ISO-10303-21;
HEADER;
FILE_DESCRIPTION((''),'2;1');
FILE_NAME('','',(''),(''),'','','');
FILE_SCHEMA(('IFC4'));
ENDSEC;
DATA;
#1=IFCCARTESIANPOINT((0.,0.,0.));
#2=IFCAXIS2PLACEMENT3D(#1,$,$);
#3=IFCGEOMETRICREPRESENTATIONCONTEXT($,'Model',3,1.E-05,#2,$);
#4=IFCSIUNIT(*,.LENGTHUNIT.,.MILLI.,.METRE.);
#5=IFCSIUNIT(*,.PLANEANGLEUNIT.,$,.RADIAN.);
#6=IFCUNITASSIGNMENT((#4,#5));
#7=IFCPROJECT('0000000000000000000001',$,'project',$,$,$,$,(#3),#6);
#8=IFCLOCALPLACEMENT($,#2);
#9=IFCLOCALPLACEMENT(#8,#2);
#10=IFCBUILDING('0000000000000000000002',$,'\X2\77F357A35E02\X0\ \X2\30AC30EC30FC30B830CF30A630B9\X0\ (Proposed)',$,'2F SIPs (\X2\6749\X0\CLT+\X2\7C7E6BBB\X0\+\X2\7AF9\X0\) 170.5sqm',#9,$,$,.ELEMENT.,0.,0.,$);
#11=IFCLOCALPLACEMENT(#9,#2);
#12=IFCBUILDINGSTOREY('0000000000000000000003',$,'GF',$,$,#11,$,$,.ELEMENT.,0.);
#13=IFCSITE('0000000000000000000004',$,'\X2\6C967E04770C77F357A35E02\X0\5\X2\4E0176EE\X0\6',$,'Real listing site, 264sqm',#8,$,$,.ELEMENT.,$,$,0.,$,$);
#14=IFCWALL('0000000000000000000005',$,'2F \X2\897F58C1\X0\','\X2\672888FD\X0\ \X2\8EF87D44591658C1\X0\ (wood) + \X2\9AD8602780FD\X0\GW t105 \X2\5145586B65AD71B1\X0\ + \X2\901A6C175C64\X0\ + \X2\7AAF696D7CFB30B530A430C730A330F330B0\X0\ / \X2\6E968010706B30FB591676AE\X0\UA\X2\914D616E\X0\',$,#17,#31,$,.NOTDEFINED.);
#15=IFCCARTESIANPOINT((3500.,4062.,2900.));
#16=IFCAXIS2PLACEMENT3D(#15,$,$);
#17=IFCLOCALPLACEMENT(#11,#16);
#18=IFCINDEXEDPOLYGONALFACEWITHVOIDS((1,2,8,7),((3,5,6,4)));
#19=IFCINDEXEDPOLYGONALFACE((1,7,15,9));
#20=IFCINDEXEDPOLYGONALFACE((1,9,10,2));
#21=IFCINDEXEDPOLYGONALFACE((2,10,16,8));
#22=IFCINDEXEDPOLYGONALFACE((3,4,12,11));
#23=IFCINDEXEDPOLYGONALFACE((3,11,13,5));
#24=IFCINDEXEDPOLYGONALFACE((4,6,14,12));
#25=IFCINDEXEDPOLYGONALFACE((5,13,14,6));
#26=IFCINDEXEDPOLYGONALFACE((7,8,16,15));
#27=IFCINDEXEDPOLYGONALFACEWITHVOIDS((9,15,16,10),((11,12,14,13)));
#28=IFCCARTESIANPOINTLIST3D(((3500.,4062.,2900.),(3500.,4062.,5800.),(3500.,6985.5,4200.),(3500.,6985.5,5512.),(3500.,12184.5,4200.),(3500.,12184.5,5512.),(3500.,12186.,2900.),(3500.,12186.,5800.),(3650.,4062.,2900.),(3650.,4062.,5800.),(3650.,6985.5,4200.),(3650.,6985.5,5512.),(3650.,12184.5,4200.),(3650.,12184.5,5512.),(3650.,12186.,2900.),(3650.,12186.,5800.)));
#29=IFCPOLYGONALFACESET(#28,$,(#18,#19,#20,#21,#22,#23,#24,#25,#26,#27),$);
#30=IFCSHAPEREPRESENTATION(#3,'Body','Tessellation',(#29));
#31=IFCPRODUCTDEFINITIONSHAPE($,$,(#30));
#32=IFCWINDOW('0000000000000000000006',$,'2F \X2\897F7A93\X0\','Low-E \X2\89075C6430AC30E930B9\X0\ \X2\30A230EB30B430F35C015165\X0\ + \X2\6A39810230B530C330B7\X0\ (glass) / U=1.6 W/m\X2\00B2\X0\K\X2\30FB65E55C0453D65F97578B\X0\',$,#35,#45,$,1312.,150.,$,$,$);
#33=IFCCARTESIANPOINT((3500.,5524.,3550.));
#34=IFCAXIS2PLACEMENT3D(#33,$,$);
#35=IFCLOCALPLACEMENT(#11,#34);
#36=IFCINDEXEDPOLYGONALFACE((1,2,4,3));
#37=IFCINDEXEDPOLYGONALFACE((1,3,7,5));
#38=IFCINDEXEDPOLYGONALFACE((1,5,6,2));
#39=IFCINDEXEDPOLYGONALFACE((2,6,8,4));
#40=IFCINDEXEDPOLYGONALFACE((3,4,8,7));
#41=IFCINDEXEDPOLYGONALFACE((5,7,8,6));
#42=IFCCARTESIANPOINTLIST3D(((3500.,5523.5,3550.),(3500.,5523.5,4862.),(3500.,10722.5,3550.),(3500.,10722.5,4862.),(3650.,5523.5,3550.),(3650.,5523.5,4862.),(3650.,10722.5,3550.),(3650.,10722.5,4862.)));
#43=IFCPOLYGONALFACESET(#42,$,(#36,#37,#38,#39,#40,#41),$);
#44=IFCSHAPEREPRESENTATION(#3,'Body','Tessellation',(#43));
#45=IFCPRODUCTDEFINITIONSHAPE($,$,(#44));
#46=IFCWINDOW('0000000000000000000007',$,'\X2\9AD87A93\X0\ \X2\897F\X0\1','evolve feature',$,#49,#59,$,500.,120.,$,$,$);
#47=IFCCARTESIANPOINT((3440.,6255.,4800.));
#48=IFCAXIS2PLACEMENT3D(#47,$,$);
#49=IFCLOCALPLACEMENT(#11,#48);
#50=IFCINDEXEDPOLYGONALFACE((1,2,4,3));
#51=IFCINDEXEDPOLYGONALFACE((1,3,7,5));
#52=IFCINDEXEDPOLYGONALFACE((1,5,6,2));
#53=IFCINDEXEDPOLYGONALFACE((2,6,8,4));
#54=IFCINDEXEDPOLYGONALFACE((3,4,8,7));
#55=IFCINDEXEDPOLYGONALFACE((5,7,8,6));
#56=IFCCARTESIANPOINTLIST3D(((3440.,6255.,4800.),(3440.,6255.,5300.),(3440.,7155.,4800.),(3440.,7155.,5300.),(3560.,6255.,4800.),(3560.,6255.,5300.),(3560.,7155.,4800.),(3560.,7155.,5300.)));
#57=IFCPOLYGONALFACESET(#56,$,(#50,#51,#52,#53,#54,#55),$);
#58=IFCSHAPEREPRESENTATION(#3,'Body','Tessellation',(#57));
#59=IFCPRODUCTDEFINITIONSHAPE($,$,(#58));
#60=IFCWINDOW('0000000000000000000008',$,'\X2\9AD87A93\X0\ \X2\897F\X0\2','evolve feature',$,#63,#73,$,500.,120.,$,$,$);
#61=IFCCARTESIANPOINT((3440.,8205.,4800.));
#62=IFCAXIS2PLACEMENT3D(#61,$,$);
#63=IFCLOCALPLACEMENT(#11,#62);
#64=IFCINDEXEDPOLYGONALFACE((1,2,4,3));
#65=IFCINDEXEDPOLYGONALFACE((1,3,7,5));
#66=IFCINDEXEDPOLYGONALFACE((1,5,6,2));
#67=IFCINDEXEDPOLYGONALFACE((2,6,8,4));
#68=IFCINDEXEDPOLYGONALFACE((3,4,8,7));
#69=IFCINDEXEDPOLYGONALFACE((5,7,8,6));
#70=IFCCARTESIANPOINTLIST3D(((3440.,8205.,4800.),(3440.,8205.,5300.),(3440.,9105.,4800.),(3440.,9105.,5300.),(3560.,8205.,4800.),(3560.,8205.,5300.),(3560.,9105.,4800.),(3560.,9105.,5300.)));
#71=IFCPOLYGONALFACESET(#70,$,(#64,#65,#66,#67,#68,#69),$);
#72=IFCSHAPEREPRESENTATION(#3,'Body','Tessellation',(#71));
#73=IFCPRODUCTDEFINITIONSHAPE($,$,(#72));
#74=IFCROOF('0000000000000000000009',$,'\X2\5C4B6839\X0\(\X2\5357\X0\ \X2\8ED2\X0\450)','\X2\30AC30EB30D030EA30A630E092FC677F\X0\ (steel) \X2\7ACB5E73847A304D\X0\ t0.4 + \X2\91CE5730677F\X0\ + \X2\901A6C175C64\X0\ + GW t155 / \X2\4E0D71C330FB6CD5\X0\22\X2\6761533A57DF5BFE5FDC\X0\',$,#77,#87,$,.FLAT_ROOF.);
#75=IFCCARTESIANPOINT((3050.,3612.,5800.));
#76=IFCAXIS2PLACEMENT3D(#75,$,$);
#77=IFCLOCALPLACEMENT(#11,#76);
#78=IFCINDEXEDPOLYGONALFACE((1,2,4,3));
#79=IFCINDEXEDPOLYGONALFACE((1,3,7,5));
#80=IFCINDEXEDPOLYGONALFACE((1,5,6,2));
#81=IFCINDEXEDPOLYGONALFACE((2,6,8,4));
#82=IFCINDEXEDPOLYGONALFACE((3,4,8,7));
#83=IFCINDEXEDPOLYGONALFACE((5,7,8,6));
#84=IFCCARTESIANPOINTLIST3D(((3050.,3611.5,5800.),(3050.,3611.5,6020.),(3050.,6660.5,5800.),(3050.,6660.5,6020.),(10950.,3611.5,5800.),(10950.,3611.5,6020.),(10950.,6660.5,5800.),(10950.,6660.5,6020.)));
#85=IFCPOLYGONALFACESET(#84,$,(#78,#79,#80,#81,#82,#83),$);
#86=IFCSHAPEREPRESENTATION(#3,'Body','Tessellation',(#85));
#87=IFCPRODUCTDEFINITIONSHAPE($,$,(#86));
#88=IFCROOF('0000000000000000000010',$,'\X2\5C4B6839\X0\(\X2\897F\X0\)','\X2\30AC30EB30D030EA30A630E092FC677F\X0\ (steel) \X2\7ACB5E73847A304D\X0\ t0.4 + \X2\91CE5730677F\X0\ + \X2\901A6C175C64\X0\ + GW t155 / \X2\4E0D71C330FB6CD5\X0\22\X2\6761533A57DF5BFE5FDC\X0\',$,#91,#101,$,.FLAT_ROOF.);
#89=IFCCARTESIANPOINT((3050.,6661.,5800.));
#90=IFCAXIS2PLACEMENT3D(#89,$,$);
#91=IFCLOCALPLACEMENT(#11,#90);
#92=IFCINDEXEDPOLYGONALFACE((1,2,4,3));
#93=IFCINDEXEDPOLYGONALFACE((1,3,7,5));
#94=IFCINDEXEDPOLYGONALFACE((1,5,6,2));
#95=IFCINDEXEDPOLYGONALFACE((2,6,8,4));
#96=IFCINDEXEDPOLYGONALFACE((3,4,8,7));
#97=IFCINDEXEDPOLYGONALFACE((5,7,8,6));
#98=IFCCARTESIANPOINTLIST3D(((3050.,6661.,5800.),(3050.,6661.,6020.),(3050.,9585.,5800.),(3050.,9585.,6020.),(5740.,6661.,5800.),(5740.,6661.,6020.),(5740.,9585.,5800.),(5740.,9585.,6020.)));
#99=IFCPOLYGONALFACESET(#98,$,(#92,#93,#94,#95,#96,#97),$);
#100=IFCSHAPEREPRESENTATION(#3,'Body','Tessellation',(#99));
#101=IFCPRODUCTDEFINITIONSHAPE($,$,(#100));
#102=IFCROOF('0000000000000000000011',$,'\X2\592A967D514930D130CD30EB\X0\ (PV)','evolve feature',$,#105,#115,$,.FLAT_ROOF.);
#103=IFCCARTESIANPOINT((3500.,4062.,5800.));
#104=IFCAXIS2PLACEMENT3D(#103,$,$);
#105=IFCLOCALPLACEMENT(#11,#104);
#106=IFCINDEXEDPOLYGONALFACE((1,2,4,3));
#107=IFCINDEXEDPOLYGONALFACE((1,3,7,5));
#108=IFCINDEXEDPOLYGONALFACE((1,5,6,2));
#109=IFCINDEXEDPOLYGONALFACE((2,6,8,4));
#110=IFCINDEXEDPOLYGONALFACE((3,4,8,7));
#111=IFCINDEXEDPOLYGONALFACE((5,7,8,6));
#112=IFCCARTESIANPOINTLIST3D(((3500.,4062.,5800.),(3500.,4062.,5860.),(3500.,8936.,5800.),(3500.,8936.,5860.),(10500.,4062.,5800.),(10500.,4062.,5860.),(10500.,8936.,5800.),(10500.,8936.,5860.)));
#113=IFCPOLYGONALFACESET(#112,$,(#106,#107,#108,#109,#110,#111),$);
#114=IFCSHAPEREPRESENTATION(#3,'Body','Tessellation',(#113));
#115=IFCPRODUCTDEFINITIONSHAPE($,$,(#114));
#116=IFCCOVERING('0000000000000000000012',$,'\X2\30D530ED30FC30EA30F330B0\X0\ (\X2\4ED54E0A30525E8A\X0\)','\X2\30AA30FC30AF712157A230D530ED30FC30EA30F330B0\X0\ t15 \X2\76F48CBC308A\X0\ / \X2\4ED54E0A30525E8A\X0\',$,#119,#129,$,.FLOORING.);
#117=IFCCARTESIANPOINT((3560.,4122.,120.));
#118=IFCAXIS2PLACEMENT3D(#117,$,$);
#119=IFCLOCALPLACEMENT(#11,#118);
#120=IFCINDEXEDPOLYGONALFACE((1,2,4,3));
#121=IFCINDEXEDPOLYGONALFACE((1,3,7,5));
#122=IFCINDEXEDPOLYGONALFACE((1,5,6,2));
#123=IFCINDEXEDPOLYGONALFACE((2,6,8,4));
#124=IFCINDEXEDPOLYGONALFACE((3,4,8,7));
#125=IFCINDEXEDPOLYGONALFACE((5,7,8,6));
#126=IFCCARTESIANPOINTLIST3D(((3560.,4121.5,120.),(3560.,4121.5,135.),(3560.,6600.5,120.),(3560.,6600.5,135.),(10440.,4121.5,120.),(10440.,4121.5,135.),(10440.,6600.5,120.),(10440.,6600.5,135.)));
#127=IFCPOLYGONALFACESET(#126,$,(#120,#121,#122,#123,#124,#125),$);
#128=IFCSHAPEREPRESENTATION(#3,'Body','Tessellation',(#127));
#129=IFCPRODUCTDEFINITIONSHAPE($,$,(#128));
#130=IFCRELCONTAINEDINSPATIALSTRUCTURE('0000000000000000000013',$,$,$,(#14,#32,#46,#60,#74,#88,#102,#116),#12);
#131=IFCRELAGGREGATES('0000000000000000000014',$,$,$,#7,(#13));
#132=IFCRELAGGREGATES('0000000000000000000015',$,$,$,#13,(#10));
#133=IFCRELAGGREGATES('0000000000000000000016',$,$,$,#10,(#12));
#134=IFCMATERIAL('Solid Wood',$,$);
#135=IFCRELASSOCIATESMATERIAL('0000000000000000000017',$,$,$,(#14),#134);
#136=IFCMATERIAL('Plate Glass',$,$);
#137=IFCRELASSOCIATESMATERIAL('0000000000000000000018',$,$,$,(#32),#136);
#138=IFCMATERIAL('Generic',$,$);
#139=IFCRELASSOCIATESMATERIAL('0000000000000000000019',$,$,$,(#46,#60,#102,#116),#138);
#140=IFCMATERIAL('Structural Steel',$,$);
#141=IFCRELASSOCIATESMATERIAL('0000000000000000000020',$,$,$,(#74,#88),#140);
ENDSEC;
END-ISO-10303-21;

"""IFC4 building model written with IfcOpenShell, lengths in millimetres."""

from ifc_helpers import new_model, si_unit, frame, frame_2d, origin, place, context, project, spatial, rectangle, extrude, material, element, fill, save


model = new_model("IFC4")

# Units and contexts
model_context = context("Model", 3, precision=1e-05, world=origin())
ifc_project = project(units=[si_unit("LENGTHUNIT", "METRE", prefix="MILLI"), si_unit("PLANEANGLEUNIT", "RADIAN")], contexts=[model_context])

# Site, building, storey
site_placement = place(None, origin())
site = spatial("IfcSite", under=ifc_project, at=site_placement, Name="沖縄県石垣市5丁目6", ObjectType="Real listing site, 264sqm", CompositionType="ELEMENT", RefElevation=0.0)
building_placement = place(site_placement, origin())
building = spatial("IfcBuilding", under=site, at=building_placement, Name="石垣市 ガレージハウス (Proposed)", ObjectType="2F SIPs (杉CLT+籾殻+竹) 170.5sqm", CompositionType="ELEMENT", ElevationOfRefHeight=0.0, ElevationOfTerrain=0.0)
storey_placement = place(building_placement, origin())
storey = spatial("IfcBuildingStorey", under=building, at=storey_placement, Name="GF", CompositionType="ELEMENT", Elevation=0.0)

# Shared definitions
ifc_material_1 = material(Name="Solid Wood")
ifc_material_2 = material(Name="Generic")

# Shared definitions
ifc_material_3 = material(Name="Plate Glass")

# Wall, openings, windows
wall_1_placement = place(storey_placement, frame((3500.0, 4062.0, 2900.0)))
wall_1 = element("IfcWall", 1, at=wall_1_placement, inside=storey, material=ifc_material_1, Name="2F 西壁", Description="木製 軸組外壁 (wood) + 高性能GW t105 充填断熱 + 通気層 + 窯業系サイディング / 準耐火・外皮UA配慮", PredefinedType="NOTDEFINED", context=model_context, shape_type="SweptSolid", body=[
    extrude(rectangle(XDim=150.0, YDim=8124.0, at=frame_2d((75.0, 4062.0))), frame((3500.0, 4062.0, 2900.0)), (0.0, 0.0, 1.0), 2900.0),
])
opening_1_placement = place(storey_placement, frame((3500.0, 5524.0, 3550.0)))
opening_1 = element("IfcOpeningElement", 2, at=opening_1_placement, cuts=wall_1, PredefinedType="NOTDEFINED", context=model_context, shape_type="SweptSolid", body=[
    extrude(rectangle(XDim=150.0, YDim=5199.0, at=frame_2d((75.0, 2599.0))), frame((3500.0, 5524.0, 3550.0)), (0.0, 0.0, 1.0), 1312.0),
])
opening_2_placement = place(storey_placement, frame((3440.0, 6255.0, 4800.0)))
opening_2 = element("IfcOpeningElement", 3, at=opening_2_placement, cuts=wall_1, PredefinedType="NOTDEFINED", context=model_context, shape_type="SweptSolid", body=[
    extrude(rectangle(XDim=120.0, YDim=900.0, at=frame_2d((60.0, 450.0))), frame((3440.0, 6255.0, 4800.0)), (0.0, 0.0, 1.0), 500.0),
])
opening_3_placement = place(storey_placement, frame((3440.0, 8205.0, 4800.0)))
opening_3 = element("IfcOpeningElement", 4, at=opening_3_placement, cuts=wall_1, PredefinedType="NOTDEFINED", context=model_context, shape_type="SweptSolid", body=[
    extrude(rectangle(XDim=120.0, YDim=900.0, at=frame_2d((60.0, 450.0))), frame((3440.0, 8205.0, 4800.0)), (0.0, 0.0, 1.0), 500.0),
])
window_1_placement = place(storey_placement, frame((3500.0, 5524.0, 3550.0)))
window_1 = element("IfcWindow", 5, at=window_1_placement, inside=storey, material=ifc_material_3, Name="2F 西窓", Description="Low-E 複層ガラス アルゴン封入 + 樹脂サッシ (glass) / U=1.6 W/m²K・日射取得型", OverallHeight=1312.0, OverallWidth=150.0, context=model_context, shape_type="SweptSolid", body=[
    extrude(rectangle(XDim=150.0, YDim=5199.0, at=frame_2d((75.0, 2599.0))), frame((3500.0, 5524.0, 3550.0)), (0.0, 0.0, 1.0), 1312.0),
])
fill(opening_1, window_1)
window_2_placement = place(storey_placement, frame((3440.0, 6255.0, 4800.0)))
window_2 = element("IfcWindow", 6, at=window_2_placement, inside=storey, material=ifc_material_2, Name="高窓 西1", Description="evolve feature", OverallHeight=500.0, OverallWidth=120.0, context=model_context, shape_type="SweptSolid", body=[
    extrude(rectangle(XDim=120.0, YDim=900.0, at=frame_2d((60.0, 450.0))), frame((3440.0, 6255.0, 4800.0)), (0.0, 0.0, 1.0), 500.0),
])
fill(opening_2, window_2)
window_3_placement = place(storey_placement, frame((3440.0, 8205.0, 4800.0)))
window_3 = element("IfcWindow", 7, at=window_3_placement, inside=storey, material=ifc_material_2, Name="高窓 西2", Description="evolve feature", OverallHeight=500.0, OverallWidth=120.0, context=model_context, shape_type="SweptSolid", body=[
    extrude(rectangle(XDim=120.0, YDim=900.0, at=frame_2d((60.0, 450.0))), frame((3440.0, 8205.0, 4800.0)), (0.0, 0.0, 1.0), 500.0),
])
fill(opening_3, window_3)

# Roofs
ifc_material_4 = material(Name="Structural Steel")
roof_1_placement = place(storey_placement, frame((3050.0, 3612.0, 5800.0)))
element("IfcRoof", 8, at=roof_1_placement, inside=storey, material=ifc_material_4, Name="屋根(南 軒450)", Description="ガルバリウム鋼板 (steel) 立平葺き t0.4 + 野地板 + 通気層 + GW t155 / 不燃・法22条区域対応", PredefinedType="FLAT_ROOF", context=model_context, shape_type="SweptSolid", body=[
    extrude(rectangle(XDim=7900.0, YDim=3049.0, at=frame_2d((3950.0, 1524.0))), frame((3050.0, 3612.0, 5800.0)), (0.0, 0.0, 1.0), 220.0),
])
roof_2_placement = place(storey_placement, frame((3050.0, 6661.0, 5800.0)))
element("IfcRoof", 9, at=roof_2_placement, inside=storey, material=ifc_material_4, Name="屋根(西)", Description="ガルバリウム鋼板 (steel) 立平葺き t0.4 + 野地板 + 通気層 + GW t155 / 不燃・法22条区域対応", PredefinedType="FLAT_ROOF", context=model_context, shape_type="SweptSolid", body=[
    extrude(rectangle(XDim=2690.0, YDim=2924.0, at=frame_2d((1345.0, 1462.0))), frame((3050.0, 6661.0, 5800.0)), (0.0, 0.0, 1.0), 220.0),
])
roof_3_placement = place(storey_placement, frame((3500.0, 4062.0, 5800.0)))
element("IfcRoof", 10, at=roof_3_placement, inside=storey, material=ifc_material_2, Name="太陽光パネル (PV)", Description="evolve feature", PredefinedType="FLAT_ROOF", context=model_context, shape_type="SweptSolid", body=[
    extrude(rectangle(XDim=7000.0, YDim=4874.0, at=frame_2d((3500.0, 2437.0))), frame((3500.0, 4062.0, 5800.0)), (0.0, 0.0, 1.0), 60.0),
])

# Covering
covering_placement = place(storey_placement, frame((3560.0, 4122.0, 120.0)))
element("IfcCovering", 11, at=covering_placement, inside=storey, material=ifc_material_2, Name="フローリング (仕上げ床)", Description="オーク無垢フローリング t15 直貼り / 仕上げ床", PredefinedType="FLOORING", context=model_context, shape_type="SweptSolid", body=[
    extrude(rectangle(XDim=6880.0, YDim=2479.0, at=frame_2d((3440.0, 1239.0))), frame((3560.0, 4122.0, 120.0)), (0.0, 0.0, 1.0), 15.0),
])

save(model, "model.ifc")
